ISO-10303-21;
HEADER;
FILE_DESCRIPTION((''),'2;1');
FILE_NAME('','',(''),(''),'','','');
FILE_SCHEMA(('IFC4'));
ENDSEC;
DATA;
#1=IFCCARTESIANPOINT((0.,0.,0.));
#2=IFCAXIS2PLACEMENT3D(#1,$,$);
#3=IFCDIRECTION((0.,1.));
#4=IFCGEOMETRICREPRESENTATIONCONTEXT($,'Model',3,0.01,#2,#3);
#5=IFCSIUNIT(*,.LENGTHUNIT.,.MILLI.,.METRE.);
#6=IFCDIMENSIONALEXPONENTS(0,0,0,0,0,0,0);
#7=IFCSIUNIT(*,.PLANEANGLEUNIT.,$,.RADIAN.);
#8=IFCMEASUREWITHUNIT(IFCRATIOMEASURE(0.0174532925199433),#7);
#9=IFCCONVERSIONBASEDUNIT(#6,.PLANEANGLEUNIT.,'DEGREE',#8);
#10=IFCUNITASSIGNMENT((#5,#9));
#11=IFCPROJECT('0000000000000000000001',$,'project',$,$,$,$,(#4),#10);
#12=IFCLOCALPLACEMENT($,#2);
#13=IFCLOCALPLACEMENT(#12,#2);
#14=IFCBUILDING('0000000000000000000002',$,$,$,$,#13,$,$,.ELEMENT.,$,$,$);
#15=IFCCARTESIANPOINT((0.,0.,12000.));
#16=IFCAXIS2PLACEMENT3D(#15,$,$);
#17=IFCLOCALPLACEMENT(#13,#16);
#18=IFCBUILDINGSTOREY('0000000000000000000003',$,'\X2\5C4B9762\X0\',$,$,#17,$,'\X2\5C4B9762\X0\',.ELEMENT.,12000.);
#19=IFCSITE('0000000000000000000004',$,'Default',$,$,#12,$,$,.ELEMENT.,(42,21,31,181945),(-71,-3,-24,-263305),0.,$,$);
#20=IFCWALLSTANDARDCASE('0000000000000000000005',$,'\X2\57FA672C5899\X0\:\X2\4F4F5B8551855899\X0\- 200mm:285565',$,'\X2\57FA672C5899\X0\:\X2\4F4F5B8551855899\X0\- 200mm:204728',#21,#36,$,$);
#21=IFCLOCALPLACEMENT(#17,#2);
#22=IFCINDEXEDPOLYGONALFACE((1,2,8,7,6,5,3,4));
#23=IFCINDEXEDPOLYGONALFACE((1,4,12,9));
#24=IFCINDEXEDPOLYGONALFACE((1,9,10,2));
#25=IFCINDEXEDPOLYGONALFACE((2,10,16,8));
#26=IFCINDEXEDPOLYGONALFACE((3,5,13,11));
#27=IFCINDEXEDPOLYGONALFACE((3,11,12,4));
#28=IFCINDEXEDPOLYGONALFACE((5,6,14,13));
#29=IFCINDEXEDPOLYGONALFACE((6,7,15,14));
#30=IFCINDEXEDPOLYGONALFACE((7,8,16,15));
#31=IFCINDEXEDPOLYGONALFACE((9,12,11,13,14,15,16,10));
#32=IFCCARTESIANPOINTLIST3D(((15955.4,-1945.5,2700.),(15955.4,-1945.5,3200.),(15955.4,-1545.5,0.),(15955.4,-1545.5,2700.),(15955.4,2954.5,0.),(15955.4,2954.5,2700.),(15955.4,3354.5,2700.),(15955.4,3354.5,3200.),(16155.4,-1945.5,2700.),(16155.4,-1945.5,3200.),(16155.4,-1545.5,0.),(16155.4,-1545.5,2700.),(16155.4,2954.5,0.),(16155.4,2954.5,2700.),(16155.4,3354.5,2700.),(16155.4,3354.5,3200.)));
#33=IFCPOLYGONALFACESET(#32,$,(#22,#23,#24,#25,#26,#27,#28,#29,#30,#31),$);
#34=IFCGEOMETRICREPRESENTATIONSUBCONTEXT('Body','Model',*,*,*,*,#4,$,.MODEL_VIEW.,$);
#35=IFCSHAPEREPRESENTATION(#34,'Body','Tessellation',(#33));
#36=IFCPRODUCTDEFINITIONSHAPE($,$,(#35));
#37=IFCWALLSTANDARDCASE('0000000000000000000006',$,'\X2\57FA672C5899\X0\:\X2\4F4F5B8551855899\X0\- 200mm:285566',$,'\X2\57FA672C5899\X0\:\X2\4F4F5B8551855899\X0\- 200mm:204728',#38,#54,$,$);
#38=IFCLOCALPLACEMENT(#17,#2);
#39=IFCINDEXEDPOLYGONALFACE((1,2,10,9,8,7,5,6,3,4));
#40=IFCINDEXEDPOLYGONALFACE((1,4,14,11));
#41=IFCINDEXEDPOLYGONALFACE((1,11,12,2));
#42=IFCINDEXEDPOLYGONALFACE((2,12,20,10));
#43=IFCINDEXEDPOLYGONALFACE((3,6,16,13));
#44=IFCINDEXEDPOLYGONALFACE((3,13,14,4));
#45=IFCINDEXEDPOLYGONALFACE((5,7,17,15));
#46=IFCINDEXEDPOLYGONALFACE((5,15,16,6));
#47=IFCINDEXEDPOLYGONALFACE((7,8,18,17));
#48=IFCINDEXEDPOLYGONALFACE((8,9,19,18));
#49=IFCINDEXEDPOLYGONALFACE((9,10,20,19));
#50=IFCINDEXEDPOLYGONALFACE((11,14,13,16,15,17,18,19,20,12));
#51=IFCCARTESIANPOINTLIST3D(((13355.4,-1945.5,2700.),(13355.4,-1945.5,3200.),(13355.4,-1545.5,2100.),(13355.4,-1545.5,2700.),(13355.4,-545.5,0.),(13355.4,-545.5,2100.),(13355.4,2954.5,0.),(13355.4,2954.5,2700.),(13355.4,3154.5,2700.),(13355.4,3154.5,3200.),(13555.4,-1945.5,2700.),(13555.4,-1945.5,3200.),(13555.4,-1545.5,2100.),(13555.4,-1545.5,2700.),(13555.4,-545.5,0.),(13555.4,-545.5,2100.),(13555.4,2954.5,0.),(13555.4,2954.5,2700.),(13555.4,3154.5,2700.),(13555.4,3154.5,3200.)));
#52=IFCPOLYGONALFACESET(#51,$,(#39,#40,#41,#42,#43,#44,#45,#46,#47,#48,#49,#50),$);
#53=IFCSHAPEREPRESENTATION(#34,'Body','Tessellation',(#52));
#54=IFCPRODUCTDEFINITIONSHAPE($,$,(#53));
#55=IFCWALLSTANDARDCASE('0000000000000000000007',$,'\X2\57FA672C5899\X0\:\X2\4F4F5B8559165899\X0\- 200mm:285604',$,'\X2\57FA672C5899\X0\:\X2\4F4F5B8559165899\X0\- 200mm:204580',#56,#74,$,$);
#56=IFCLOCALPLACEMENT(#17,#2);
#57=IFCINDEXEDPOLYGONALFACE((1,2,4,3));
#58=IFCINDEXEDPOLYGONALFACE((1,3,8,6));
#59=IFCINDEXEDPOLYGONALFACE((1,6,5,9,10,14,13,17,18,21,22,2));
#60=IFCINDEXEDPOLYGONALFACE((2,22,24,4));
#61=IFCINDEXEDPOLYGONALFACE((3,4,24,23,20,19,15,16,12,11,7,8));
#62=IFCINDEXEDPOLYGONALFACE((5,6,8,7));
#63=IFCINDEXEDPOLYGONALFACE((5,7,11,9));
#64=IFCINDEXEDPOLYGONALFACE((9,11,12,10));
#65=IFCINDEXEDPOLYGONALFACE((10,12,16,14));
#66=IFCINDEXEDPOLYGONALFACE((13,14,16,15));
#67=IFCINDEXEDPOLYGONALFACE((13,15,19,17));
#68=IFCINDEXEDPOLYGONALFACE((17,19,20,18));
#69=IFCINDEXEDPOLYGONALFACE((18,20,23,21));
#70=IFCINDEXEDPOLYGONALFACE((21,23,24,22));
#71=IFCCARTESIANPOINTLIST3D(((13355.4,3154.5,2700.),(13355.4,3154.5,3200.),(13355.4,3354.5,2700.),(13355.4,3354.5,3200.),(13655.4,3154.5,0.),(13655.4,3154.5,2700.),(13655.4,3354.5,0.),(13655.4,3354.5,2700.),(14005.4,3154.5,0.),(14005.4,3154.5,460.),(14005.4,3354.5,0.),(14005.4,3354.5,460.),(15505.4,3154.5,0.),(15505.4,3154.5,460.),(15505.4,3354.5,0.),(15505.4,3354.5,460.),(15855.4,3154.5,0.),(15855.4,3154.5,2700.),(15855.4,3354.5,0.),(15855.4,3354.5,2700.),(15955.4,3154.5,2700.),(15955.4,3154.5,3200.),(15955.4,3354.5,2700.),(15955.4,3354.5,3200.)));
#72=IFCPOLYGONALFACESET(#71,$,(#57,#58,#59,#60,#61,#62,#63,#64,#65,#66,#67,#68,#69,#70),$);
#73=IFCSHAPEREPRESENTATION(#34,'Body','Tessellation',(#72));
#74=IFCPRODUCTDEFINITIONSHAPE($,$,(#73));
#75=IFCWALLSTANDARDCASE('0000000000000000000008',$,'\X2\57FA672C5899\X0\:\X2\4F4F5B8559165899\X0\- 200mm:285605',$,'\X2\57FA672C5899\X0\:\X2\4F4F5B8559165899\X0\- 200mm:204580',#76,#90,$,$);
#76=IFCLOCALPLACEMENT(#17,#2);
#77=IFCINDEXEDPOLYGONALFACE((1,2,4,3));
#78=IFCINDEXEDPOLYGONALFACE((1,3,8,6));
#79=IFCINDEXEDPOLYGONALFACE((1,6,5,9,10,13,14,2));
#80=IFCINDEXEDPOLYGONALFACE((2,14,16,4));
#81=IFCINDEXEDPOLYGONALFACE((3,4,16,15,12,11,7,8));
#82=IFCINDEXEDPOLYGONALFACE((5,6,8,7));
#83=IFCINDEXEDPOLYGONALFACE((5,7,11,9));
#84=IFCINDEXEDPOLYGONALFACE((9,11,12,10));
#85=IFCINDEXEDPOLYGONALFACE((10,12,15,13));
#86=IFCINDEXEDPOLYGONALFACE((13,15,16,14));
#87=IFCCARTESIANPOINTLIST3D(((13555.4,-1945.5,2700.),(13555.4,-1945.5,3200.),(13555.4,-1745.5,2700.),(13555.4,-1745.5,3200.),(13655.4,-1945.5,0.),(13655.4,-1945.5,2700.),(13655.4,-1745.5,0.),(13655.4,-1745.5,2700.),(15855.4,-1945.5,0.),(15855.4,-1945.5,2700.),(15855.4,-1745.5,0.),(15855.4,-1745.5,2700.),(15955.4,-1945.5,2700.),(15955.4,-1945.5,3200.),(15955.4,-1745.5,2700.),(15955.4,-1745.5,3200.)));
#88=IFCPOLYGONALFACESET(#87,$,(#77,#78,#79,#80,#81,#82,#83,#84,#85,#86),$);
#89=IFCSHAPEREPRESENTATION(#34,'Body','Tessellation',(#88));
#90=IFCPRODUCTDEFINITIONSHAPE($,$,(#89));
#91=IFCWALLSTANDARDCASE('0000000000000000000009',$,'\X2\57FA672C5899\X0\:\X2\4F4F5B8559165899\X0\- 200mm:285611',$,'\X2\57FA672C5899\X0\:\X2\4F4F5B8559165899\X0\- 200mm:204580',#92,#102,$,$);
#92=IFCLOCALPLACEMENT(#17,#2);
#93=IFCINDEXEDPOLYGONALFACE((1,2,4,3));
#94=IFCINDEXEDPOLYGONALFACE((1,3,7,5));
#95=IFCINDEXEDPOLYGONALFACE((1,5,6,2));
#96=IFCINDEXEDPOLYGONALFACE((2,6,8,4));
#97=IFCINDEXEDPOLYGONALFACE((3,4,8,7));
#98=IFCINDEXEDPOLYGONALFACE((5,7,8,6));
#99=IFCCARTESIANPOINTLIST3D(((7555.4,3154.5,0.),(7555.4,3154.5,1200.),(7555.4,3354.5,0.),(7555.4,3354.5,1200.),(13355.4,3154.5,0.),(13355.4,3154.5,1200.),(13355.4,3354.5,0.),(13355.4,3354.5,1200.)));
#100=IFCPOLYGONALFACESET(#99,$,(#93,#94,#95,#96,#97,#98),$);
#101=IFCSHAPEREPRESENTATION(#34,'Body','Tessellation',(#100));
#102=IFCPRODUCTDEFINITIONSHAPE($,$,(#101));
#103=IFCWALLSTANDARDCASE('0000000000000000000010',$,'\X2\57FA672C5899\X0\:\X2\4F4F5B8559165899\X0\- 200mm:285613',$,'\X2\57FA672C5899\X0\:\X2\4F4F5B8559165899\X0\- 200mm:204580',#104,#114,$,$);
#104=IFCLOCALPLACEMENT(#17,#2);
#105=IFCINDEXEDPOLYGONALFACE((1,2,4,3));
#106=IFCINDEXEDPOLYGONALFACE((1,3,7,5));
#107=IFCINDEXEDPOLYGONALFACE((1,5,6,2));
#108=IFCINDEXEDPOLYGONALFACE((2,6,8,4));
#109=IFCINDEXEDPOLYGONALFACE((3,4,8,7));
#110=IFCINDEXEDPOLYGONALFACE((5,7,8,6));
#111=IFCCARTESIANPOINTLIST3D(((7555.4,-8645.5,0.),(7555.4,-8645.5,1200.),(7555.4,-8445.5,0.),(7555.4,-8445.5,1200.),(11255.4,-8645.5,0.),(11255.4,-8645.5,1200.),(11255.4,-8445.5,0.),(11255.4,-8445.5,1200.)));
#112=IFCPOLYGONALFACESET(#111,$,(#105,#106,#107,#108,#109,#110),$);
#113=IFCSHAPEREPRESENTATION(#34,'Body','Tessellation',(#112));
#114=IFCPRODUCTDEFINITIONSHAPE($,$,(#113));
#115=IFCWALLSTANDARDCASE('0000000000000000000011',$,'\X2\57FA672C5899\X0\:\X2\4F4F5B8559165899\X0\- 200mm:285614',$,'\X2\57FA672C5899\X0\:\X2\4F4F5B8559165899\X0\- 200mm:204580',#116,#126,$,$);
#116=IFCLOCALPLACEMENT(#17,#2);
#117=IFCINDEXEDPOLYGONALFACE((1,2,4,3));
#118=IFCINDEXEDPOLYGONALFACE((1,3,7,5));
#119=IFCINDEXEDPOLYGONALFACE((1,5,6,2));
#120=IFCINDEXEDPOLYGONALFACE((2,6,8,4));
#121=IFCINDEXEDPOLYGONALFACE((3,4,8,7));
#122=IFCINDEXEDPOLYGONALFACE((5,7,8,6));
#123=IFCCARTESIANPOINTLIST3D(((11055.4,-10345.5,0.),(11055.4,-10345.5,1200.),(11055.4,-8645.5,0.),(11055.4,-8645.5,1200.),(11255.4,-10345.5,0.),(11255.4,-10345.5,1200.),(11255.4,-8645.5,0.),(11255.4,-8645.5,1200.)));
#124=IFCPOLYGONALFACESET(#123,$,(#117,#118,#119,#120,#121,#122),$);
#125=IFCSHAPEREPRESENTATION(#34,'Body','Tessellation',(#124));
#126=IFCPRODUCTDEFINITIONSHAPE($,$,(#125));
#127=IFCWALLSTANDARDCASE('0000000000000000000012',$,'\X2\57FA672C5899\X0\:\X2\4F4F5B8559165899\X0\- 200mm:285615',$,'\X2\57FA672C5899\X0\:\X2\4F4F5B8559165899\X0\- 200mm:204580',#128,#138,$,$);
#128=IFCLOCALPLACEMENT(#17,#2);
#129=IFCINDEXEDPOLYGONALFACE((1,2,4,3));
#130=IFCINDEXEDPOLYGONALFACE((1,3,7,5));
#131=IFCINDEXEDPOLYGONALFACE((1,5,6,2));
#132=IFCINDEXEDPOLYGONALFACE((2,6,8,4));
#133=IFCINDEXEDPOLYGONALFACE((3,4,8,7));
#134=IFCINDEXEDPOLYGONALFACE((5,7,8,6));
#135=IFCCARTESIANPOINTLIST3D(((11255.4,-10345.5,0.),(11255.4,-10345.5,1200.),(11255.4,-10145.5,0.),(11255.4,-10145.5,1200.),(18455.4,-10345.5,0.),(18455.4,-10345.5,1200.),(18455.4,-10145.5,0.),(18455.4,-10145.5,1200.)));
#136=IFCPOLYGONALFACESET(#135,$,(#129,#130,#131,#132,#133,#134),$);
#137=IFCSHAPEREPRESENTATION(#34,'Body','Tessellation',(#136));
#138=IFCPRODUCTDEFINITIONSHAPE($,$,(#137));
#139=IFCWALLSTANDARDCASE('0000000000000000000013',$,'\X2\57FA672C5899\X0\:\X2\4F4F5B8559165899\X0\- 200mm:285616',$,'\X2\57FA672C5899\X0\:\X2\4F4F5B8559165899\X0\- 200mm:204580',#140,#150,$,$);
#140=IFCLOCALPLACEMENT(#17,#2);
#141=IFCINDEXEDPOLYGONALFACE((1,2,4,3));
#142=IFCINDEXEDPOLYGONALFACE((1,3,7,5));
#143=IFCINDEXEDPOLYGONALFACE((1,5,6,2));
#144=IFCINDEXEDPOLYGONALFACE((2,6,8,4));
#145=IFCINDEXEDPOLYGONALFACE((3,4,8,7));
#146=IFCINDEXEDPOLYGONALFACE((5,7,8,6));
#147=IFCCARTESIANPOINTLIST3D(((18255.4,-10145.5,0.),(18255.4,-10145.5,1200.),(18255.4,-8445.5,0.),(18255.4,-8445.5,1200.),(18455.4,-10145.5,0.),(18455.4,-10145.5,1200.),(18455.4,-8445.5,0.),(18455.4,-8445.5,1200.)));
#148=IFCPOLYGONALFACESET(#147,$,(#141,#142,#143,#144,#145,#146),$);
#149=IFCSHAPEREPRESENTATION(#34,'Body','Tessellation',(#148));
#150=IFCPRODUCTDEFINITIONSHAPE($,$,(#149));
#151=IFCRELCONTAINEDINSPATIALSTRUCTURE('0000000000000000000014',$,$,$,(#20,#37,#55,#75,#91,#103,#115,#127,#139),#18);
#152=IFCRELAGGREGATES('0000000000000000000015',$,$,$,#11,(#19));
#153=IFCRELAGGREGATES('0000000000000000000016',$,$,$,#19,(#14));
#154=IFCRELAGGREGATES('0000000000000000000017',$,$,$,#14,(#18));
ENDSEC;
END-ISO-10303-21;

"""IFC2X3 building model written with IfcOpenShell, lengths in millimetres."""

from ifc_helpers import new_model, entity, si_unit, converted_unit, direction, frame, frame_2d, origin, place, context, subcontext, project, spatial, polyline, rectangle, extrude, clip, bounded_halfspace, element, save


model = new_model("IFC2X3")

# Units and contexts
model_context = context("Model", 3, precision=0.01, world=origin(), true_north=direction((0.0, 1.0)))
body_context = subcontext(model_context, "Body", "Model", "MODEL_VIEW")
ifc_project = project(units=[si_unit("LENGTHUNIT", "METRE", prefix="MILLI"), converted_unit("PLANEANGLEUNIT", "DEGREE", entity("IfcRatioMeasure", 0.0174532925199433), si_unit("PLANEANGLEUNIT", "RADIAN"), dimensions=[0, 0, 0, 0, 0, 0, 0])], contexts=[model_context])

# Site, building, storey
site_placement = place(None, origin())
site = spatial("IfcSite", under=ifc_project, at=site_placement, Name="Default", CompositionType="ELEMENT", RefLatitude=(42, 21, 31, 181945), RefLongitude=(-71, -3, -24, -263305), RefElevation=0.0)
building_placement = place(site_placement, origin())
building = spatial("IfcBuilding", under=site, at=building_placement, CompositionType="ELEMENT")
storey_placement = place(building_placement, frame((0.0, 0.0, 12000.0)))
storey = spatial("IfcBuildingStorey", under=building, at=storey_placement, Name="屋面", LongName="屋面", CompositionType="ELEMENT", Elevation=12000.0)

# Wall
wall_1_placement = place(storey_placement, frame((16055.4, 3354.5, 0.0), z_axis=(0.0, 0.0, 1.0), x_axis=(0.0, -1.0, 0.0)))
element("IfcWallStandardCase", 1, at=wall_1_placement, inside=storey, Name="基本墙:住宅内墙- 200mm:285565", ObjectType="基本墙:住宅内墙- 200mm:204728", context=body_context, shape_type="Clipping", body=[
    clip(clip(clip(clip(extrude(rectangle(XDim=5300.0, YDim=200.0, at=frame_2d((2650.0, 0.0), x_axis=(-1.0, 0.0))), origin(), (0.0, 0.0, 1.0), 3200.0), bounded_halfspace(frame((400.0, -100.0, 2700.0), z_axis=(-1.0, 0.0, 0.0), x_axis=(0.0, 0.0, -1.0)), False, frame((400.0, -100.0, 2700.0), z_axis=(-1.0, 0.0, 0.0), x_axis=(0.0, 0.0, -1.0)), polyline([(0.0, 0.0), (0.0, -200.0), (2700.0, -200.0), (2700.0, 0.0), (0.0, 0.0)]))), bounded_halfspace(frame((400.0, 100.0, 2700.0), z_axis=(0.0, 0.0, -1.0), x_axis=(0.0, 1.0, 0.0)), False, frame((400.0, 100.0, 2700.0), z_axis=(0.0, 0.0, -1.0), x_axis=(0.0, 1.0, 0.0)), polyline([(0.0, 0.0), (-200.0, 0.0), (-200.0, -200.0), (-200.0, -400.0), (0.0, -400.0), (0.0, 0.0)]))), bounded_halfspace(frame((4900.0, 100.0, 2700.0), z_axis=(-1.0, 0.0, 0.0), x_axis=(0.0, 0.0, -1.0)), True, frame((4900.0, 100.0, 2700.0), z_axis=(-1.0, 0.0, 0.0), x_axis=(0.0, 0.0, -1.0)), polyline([(0.0, 0.0), (2700.0, 0.0), (2700.0, 200.0), (0.0, 200.0), (0.0, 0.0)]))), bounded_halfspace(frame((4900.0, -100.0, 2700.0), z_axis=(0.0, 0.0, 1.0), x_axis=(0.0, -1.0, 0.0)), True, frame((4900.0, -100.0, 2700.0), z_axis=(0.0, 0.0, 1.0), x_axis=(0.0, -1.0, 0.0)), polyline([(0.0, 0.0), (0.0, 200.0), (0.0, 400.0), (-200.0, 400.0), (-200.0, 0.0), (0.0, 0.0)]))),
])

# Walls, openings
wall_2_placement = place(storey_placement, frame((13455.4, -1945.5, 0.0), z_axis=(0.0, 0.0, 1.0), x_axis=(0.0, 1.0, 0.0)))
wall_2 = element("IfcWallStandardCase", 2, at=wall_2_placement, inside=storey, Name="基本墙:住宅内墙- 200mm:285566", ObjectType="基本墙:住宅内墙- 200mm:204728", context=body_context, shape_type="Clipping", body=[
    clip(clip(clip(clip(extrude(rectangle(XDim=5100.0, YDim=200.0, at=frame_2d((2550.0, 0.0), x_axis=(-1.0, 0.0))), origin(), (0.0, 0.0, 1.0), 3200.0), bounded_halfspace(frame((400.0, -100.0, 2700.0), z_axis=(1.0, 0.0, 0.0), x_axis=(0.0, 0.0, -1.0)), True, frame((400.0, -100.0, 2700.0), z_axis=(1.0, 0.0, 0.0), x_axis=(0.0, 0.0, -1.0)), polyline([(0.0, 0.0), (600.0, 0.0), (600.0, 200.0), (0.0, 200.0), (0.0, 0.0)]))), bounded_halfspace(frame((400.0, 100.0, 2700.0), z_axis=(0.0, 0.0, 1.0), x_axis=(0.0, 1.0, 0.0)), True, frame((400.0, 100.0, 2700.0), z_axis=(0.0, 0.0, 1.0), x_axis=(0.0, 1.0, 0.0)), polyline([(0.0, 0.0), (0.0, 400.0), (-200.0, 400.0), (-200.0, 200.0), (-200.0, 0.0), (0.0, 0.0)]))), bounded_halfspace(frame((4900.0, 100.0, 2700.0), z_axis=(-1.0, 0.0, 0.0), x_axis=(0.0, 0.0, -1.0)), True, frame((4900.0, 100.0, 2700.0), z_axis=(-1.0, 0.0, 0.0), x_axis=(0.0, 0.0, -1.0)), polyline([(0.0, 0.0), (2700.0, 0.0), (2700.0, 200.0), (0.0, 200.0), (0.0, 0.0)]))), bounded_halfspace(frame((4900.0, -100.0, 2700.0), z_axis=(0.0, 0.0, 1.0), x_axis=(0.0, 1.0, 0.0)), True, frame((4900.0, -100.0, 2700.0), z_axis=(0.0, 0.0, 1.0), x_axis=(0.0, 1.0, 0.0)), polyline([(0.0, 0.0), (0.0, -200.0), (200.0, -200.0), (200.0, 0.0), (0.0, 0.0)]))),
])
opening_1_placement = place(wall_2_placement, frame((1400.0, 100.0, 0.0)))
element("IfcOpeningElement", 3, at=opening_1_placement, cuts=wall_2, ObjectType="Opening", context=body_context, shape_type="SweptSolid", body=[
    extrude(rectangle(XDim=2100.0, YDim=1000.0, at=frame_2d((1050.0, 500.0), x_axis=(1.0, 0.0))), frame((0.0, 0.0, 0.0), z_axis=(0.0, -1.0, 0.0), x_axis=(0.0, 0.0, 1.0)), (0.0, 0.0, 1.0), 200.0),
])
wall_3_placement = place(storey_placement, frame((15955.4, 3254.5, 0.0), z_axis=(0.0, 0.0, 1.0), x_axis=(-1.0, 0.0, 0.0)))
wall_3 = element("IfcWallStandardCase", 4, at=wall_3_placement, inside=storey, Name="基本墙:住宅外墙- 200mm:285604", ObjectType="基本墙:住宅外墙- 200mm:204580", context=body_context, shape_type="Clipping", body=[
    clip(clip(clip(clip(extrude(rectangle(XDim=2600.0, YDim=200.0, at=frame_2d((1300.0, 0.0), x_axis=(-1.0, 0.0))), origin(), (0.0, 0.0, 1.0), 3200.0), bounded_halfspace(frame((2300.0, 100.0, 2700.0), z_axis=(-1.0, 0.0, 0.0), x_axis=(0.0, 0.0, -1.0)), True, frame((2300.0, 100.0, 2700.0), z_axis=(-1.0, 0.0, 0.0), x_axis=(0.0, 0.0, -1.0)), polyline([(0.0, 0.0), (2700.0, 0.0), (2700.0, 200.0), (0.0, 200.0), (0.0, 0.0)]))), bounded_halfspace(frame((2300.0, -100.0, 2700.0)), True, frame((2300.0, -100.0, 2700.0)), polyline([(0.0, 0.0), (300.0, 0.0), (300.0, 200.0), (100.0, 200.0), (0.0, 200.0), (0.0, 0.0)]))), bounded_halfspace(frame((100.0, -100.0, 2700.0), z_axis=(-1.0, 0.0, 0.0), x_axis=(0.0, 0.0, -1.0)), False, frame((100.0, -100.0, 2700.0), z_axis=(-1.0, 0.0, 0.0), x_axis=(0.0, 0.0, -1.0)), polyline([(0.0, 0.0), (0.0, -200.0), (2700.0, -200.0), (2700.0, 0.0), (0.0, 0.0)]))), bounded_halfspace(frame((100.0, 100.0, 2700.0), z_axis=(0.0, 0.0, -1.0), x_axis=(-1.0, 0.0, 0.0)), False, frame((100.0, 100.0, 2700.0), z_axis=(0.0, 0.0, -1.0), x_axis=(-1.0, 0.0, 0.0)), polyline([(0.0, 0.0), (0.0, -200.0), (100.0, -200.0), (100.0, 0.0), (0.0, 0.0)]))),
])
opening_2_placement = place(wall_3_placement, origin())
element("IfcOpeningElement", 5, at=opening_2_placement, cuts=wall_3, ObjectType="Opening", context=body_context, shape_type="SweptSolid", body=[
    extrude(rectangle(XDim=500.0, YDim=1500.0, at=frame_2d((0.0, 0.0), x_axis=(0.0, 1.0))), frame((1200.0, -1424.0, 210.0), z_axis=(0.0, 1.0, 0.0), x_axis=(-1.0, 0.0, 0.0)), (0.0, 0.0, 1.0), 3048.0),
])

# Walls
wall_4_placement = place(storey_placement, frame((15955.4, -1845.5, 0.0), z_axis=(0.0, 0.0, 1.0), x_axis=(-1.0, 0.0, 0.0)))
element("IfcWallStandardCase", 6, at=wall_4_placement, inside=storey, Name="基本墙:住宅外墙- 200mm:285605", ObjectType="基本墙:住宅外墙- 200mm:204580", context=body_context, shape_type="Clipping", body=[
    clip(clip(clip(clip(extrude(rectangle(XDim=2400.0, YDim=200.0, at=frame_2d((1200.0, 0.0), x_axis=(-1.0, 0.0))), origin(), (0.0, 0.0, 1.0), 3200.0), bounded_halfspace(frame((2300.0, 100.0, 2700.0), z_axis=(-1.0, 0.0, 0.0), x_axis=(0.0, 0.0, -1.0)), True, frame((2300.0, 100.0, 2700.0), z_axis=(-1.0, 0.0, 0.0), x_axis=(0.0, 0.0, -1.0)), polyline([(0.0, 0.0), (2700.0, 0.0), (2700.0, 200.0), (0.0, 200.0), (0.0, 0.0)]))), bounded_halfspace(frame((2300.0, -100.0, 2700.0)), True, frame((2300.0, -100.0, 2700.0)), polyline([(0.0, 0.0), (100.0, 0.0), (100.0, 200.0), (0.0, 200.0), (0.0, 0.0)]))), bounded_halfspace(frame((100.0, -100.0, 2700.0), z_axis=(1.0, 0.0, 0.0), x_axis=(0.0, 0.0, -1.0)), True, frame((100.0, -100.0, 2700.0), z_axis=(1.0, 0.0, 0.0), x_axis=(0.0, 0.0, -1.0)), polyline([(0.0, 0.0), (2700.0, 0.0), (2700.0, 200.0), (0.0, 200.0), (0.0, 0.0)]))), bounded_halfspace(frame((100.0, 100.0, 2700.0)), True, frame((100.0, 100.0, 2700.0)), polyline([(0.0, 0.0), (-100.0, 0.0), (-100.0, -200.0), (0.0, -200.0), (0.0, 0.0)]))),
])
wall_5_placement = place(storey_placement, frame((13355.4, 3254.5, 0.0), z_axis=(0.0, 0.0, 1.0), x_axis=(-1.0, 0.0, 0.0)))
element("IfcWallStandardCase", 7, at=wall_5_placement, inside=storey, Name="基本墙:住宅外墙- 200mm:285611", ObjectType="基本墙:住宅外墙- 200mm:204580", context=body_context, shape_type="SweptSolid", body=[
    extrude(rectangle(XDim=5800.0, YDim=200.0, at=frame_2d((2900.0, 0.0), x_axis=(-1.0, 0.0))), origin(), (0.0, 0.0, 1.0), 1200.0),
])
wall_6_placement = place(storey_placement, frame((7555.4, -8545.5, 0.0)))
element("IfcWallStandardCase", 8, at=wall_6_placement, inside=storey, Name="基本墙:住宅外墙- 200mm:285613", ObjectType="基本墙:住宅外墙- 200mm:204580", context=body_context, shape_type="SweptSolid", body=[
    extrude(rectangle(XDim=3700.0, YDim=200.0, at=frame_2d((1850.0, 0.0), x_axis=(-1.0, 0.0))), origin(), (0.0, 0.0, 1.0), 1200.0),
])
wall_7_placement = place(storey_placement, frame((11155.4, -8645.5, 0.0), z_axis=(0.0, 0.0, 1.0), x_axis=(0.0, -1.0, 0.0)))
element("IfcWallStandardCase", 9, at=wall_7_placement, inside=storey, Name="基本墙:住宅外墙- 200mm:285614", ObjectType="基本墙:住宅外墙- 200mm:204580", context=body_context, shape_type="SweptSolid", body=[
    extrude(rectangle(XDim=1700.0, YDim=200.0, at=frame_2d((850.0, 0.0), x_axis=(-1.0, 0.0))), origin(), (0.0, 0.0, 1.0), 1200.0),
])
wall_8_placement = place(storey_placement, frame((11255.4, -10245.5, 0.0)))
element("IfcWallStandardCase", 10, at=wall_8_placement, inside=storey, Name="基本墙:住宅外墙- 200mm:285615", ObjectType="基本墙:住宅外墙- 200mm:204580", context=body_context, shape_type="SweptSolid", body=[
    extrude(rectangle(XDim=7200.0, YDim=200.0, at=frame_2d((3600.0, 0.0), x_axis=(-1.0, 0.0))), origin(), (0.0, 0.0, 1.0), 1200.0),
])
wall_9_placement = place(storey_placement, frame((18355.4, -10145.5, 0.0), z_axis=(0.0, 0.0, 1.0), x_axis=(0.0, 1.0, 0.0)))
element("IfcWallStandardCase", 11, at=wall_9_placement, inside=storey, Name="基本墙:住宅外墙- 200mm:285616", ObjectType="基本墙:住宅外墙- 200mm:204580", context=body_context, shape_type="SweptSolid", body=[
    extrude(rectangle(XDim=1700.0, YDim=200.0, at=frame_2d((850.0, 0.0), x_axis=(-1.0, 0.0))), origin(), (0.0, 0.0, 1.0), 1200.0),
])

save(model, "model.ifc")
